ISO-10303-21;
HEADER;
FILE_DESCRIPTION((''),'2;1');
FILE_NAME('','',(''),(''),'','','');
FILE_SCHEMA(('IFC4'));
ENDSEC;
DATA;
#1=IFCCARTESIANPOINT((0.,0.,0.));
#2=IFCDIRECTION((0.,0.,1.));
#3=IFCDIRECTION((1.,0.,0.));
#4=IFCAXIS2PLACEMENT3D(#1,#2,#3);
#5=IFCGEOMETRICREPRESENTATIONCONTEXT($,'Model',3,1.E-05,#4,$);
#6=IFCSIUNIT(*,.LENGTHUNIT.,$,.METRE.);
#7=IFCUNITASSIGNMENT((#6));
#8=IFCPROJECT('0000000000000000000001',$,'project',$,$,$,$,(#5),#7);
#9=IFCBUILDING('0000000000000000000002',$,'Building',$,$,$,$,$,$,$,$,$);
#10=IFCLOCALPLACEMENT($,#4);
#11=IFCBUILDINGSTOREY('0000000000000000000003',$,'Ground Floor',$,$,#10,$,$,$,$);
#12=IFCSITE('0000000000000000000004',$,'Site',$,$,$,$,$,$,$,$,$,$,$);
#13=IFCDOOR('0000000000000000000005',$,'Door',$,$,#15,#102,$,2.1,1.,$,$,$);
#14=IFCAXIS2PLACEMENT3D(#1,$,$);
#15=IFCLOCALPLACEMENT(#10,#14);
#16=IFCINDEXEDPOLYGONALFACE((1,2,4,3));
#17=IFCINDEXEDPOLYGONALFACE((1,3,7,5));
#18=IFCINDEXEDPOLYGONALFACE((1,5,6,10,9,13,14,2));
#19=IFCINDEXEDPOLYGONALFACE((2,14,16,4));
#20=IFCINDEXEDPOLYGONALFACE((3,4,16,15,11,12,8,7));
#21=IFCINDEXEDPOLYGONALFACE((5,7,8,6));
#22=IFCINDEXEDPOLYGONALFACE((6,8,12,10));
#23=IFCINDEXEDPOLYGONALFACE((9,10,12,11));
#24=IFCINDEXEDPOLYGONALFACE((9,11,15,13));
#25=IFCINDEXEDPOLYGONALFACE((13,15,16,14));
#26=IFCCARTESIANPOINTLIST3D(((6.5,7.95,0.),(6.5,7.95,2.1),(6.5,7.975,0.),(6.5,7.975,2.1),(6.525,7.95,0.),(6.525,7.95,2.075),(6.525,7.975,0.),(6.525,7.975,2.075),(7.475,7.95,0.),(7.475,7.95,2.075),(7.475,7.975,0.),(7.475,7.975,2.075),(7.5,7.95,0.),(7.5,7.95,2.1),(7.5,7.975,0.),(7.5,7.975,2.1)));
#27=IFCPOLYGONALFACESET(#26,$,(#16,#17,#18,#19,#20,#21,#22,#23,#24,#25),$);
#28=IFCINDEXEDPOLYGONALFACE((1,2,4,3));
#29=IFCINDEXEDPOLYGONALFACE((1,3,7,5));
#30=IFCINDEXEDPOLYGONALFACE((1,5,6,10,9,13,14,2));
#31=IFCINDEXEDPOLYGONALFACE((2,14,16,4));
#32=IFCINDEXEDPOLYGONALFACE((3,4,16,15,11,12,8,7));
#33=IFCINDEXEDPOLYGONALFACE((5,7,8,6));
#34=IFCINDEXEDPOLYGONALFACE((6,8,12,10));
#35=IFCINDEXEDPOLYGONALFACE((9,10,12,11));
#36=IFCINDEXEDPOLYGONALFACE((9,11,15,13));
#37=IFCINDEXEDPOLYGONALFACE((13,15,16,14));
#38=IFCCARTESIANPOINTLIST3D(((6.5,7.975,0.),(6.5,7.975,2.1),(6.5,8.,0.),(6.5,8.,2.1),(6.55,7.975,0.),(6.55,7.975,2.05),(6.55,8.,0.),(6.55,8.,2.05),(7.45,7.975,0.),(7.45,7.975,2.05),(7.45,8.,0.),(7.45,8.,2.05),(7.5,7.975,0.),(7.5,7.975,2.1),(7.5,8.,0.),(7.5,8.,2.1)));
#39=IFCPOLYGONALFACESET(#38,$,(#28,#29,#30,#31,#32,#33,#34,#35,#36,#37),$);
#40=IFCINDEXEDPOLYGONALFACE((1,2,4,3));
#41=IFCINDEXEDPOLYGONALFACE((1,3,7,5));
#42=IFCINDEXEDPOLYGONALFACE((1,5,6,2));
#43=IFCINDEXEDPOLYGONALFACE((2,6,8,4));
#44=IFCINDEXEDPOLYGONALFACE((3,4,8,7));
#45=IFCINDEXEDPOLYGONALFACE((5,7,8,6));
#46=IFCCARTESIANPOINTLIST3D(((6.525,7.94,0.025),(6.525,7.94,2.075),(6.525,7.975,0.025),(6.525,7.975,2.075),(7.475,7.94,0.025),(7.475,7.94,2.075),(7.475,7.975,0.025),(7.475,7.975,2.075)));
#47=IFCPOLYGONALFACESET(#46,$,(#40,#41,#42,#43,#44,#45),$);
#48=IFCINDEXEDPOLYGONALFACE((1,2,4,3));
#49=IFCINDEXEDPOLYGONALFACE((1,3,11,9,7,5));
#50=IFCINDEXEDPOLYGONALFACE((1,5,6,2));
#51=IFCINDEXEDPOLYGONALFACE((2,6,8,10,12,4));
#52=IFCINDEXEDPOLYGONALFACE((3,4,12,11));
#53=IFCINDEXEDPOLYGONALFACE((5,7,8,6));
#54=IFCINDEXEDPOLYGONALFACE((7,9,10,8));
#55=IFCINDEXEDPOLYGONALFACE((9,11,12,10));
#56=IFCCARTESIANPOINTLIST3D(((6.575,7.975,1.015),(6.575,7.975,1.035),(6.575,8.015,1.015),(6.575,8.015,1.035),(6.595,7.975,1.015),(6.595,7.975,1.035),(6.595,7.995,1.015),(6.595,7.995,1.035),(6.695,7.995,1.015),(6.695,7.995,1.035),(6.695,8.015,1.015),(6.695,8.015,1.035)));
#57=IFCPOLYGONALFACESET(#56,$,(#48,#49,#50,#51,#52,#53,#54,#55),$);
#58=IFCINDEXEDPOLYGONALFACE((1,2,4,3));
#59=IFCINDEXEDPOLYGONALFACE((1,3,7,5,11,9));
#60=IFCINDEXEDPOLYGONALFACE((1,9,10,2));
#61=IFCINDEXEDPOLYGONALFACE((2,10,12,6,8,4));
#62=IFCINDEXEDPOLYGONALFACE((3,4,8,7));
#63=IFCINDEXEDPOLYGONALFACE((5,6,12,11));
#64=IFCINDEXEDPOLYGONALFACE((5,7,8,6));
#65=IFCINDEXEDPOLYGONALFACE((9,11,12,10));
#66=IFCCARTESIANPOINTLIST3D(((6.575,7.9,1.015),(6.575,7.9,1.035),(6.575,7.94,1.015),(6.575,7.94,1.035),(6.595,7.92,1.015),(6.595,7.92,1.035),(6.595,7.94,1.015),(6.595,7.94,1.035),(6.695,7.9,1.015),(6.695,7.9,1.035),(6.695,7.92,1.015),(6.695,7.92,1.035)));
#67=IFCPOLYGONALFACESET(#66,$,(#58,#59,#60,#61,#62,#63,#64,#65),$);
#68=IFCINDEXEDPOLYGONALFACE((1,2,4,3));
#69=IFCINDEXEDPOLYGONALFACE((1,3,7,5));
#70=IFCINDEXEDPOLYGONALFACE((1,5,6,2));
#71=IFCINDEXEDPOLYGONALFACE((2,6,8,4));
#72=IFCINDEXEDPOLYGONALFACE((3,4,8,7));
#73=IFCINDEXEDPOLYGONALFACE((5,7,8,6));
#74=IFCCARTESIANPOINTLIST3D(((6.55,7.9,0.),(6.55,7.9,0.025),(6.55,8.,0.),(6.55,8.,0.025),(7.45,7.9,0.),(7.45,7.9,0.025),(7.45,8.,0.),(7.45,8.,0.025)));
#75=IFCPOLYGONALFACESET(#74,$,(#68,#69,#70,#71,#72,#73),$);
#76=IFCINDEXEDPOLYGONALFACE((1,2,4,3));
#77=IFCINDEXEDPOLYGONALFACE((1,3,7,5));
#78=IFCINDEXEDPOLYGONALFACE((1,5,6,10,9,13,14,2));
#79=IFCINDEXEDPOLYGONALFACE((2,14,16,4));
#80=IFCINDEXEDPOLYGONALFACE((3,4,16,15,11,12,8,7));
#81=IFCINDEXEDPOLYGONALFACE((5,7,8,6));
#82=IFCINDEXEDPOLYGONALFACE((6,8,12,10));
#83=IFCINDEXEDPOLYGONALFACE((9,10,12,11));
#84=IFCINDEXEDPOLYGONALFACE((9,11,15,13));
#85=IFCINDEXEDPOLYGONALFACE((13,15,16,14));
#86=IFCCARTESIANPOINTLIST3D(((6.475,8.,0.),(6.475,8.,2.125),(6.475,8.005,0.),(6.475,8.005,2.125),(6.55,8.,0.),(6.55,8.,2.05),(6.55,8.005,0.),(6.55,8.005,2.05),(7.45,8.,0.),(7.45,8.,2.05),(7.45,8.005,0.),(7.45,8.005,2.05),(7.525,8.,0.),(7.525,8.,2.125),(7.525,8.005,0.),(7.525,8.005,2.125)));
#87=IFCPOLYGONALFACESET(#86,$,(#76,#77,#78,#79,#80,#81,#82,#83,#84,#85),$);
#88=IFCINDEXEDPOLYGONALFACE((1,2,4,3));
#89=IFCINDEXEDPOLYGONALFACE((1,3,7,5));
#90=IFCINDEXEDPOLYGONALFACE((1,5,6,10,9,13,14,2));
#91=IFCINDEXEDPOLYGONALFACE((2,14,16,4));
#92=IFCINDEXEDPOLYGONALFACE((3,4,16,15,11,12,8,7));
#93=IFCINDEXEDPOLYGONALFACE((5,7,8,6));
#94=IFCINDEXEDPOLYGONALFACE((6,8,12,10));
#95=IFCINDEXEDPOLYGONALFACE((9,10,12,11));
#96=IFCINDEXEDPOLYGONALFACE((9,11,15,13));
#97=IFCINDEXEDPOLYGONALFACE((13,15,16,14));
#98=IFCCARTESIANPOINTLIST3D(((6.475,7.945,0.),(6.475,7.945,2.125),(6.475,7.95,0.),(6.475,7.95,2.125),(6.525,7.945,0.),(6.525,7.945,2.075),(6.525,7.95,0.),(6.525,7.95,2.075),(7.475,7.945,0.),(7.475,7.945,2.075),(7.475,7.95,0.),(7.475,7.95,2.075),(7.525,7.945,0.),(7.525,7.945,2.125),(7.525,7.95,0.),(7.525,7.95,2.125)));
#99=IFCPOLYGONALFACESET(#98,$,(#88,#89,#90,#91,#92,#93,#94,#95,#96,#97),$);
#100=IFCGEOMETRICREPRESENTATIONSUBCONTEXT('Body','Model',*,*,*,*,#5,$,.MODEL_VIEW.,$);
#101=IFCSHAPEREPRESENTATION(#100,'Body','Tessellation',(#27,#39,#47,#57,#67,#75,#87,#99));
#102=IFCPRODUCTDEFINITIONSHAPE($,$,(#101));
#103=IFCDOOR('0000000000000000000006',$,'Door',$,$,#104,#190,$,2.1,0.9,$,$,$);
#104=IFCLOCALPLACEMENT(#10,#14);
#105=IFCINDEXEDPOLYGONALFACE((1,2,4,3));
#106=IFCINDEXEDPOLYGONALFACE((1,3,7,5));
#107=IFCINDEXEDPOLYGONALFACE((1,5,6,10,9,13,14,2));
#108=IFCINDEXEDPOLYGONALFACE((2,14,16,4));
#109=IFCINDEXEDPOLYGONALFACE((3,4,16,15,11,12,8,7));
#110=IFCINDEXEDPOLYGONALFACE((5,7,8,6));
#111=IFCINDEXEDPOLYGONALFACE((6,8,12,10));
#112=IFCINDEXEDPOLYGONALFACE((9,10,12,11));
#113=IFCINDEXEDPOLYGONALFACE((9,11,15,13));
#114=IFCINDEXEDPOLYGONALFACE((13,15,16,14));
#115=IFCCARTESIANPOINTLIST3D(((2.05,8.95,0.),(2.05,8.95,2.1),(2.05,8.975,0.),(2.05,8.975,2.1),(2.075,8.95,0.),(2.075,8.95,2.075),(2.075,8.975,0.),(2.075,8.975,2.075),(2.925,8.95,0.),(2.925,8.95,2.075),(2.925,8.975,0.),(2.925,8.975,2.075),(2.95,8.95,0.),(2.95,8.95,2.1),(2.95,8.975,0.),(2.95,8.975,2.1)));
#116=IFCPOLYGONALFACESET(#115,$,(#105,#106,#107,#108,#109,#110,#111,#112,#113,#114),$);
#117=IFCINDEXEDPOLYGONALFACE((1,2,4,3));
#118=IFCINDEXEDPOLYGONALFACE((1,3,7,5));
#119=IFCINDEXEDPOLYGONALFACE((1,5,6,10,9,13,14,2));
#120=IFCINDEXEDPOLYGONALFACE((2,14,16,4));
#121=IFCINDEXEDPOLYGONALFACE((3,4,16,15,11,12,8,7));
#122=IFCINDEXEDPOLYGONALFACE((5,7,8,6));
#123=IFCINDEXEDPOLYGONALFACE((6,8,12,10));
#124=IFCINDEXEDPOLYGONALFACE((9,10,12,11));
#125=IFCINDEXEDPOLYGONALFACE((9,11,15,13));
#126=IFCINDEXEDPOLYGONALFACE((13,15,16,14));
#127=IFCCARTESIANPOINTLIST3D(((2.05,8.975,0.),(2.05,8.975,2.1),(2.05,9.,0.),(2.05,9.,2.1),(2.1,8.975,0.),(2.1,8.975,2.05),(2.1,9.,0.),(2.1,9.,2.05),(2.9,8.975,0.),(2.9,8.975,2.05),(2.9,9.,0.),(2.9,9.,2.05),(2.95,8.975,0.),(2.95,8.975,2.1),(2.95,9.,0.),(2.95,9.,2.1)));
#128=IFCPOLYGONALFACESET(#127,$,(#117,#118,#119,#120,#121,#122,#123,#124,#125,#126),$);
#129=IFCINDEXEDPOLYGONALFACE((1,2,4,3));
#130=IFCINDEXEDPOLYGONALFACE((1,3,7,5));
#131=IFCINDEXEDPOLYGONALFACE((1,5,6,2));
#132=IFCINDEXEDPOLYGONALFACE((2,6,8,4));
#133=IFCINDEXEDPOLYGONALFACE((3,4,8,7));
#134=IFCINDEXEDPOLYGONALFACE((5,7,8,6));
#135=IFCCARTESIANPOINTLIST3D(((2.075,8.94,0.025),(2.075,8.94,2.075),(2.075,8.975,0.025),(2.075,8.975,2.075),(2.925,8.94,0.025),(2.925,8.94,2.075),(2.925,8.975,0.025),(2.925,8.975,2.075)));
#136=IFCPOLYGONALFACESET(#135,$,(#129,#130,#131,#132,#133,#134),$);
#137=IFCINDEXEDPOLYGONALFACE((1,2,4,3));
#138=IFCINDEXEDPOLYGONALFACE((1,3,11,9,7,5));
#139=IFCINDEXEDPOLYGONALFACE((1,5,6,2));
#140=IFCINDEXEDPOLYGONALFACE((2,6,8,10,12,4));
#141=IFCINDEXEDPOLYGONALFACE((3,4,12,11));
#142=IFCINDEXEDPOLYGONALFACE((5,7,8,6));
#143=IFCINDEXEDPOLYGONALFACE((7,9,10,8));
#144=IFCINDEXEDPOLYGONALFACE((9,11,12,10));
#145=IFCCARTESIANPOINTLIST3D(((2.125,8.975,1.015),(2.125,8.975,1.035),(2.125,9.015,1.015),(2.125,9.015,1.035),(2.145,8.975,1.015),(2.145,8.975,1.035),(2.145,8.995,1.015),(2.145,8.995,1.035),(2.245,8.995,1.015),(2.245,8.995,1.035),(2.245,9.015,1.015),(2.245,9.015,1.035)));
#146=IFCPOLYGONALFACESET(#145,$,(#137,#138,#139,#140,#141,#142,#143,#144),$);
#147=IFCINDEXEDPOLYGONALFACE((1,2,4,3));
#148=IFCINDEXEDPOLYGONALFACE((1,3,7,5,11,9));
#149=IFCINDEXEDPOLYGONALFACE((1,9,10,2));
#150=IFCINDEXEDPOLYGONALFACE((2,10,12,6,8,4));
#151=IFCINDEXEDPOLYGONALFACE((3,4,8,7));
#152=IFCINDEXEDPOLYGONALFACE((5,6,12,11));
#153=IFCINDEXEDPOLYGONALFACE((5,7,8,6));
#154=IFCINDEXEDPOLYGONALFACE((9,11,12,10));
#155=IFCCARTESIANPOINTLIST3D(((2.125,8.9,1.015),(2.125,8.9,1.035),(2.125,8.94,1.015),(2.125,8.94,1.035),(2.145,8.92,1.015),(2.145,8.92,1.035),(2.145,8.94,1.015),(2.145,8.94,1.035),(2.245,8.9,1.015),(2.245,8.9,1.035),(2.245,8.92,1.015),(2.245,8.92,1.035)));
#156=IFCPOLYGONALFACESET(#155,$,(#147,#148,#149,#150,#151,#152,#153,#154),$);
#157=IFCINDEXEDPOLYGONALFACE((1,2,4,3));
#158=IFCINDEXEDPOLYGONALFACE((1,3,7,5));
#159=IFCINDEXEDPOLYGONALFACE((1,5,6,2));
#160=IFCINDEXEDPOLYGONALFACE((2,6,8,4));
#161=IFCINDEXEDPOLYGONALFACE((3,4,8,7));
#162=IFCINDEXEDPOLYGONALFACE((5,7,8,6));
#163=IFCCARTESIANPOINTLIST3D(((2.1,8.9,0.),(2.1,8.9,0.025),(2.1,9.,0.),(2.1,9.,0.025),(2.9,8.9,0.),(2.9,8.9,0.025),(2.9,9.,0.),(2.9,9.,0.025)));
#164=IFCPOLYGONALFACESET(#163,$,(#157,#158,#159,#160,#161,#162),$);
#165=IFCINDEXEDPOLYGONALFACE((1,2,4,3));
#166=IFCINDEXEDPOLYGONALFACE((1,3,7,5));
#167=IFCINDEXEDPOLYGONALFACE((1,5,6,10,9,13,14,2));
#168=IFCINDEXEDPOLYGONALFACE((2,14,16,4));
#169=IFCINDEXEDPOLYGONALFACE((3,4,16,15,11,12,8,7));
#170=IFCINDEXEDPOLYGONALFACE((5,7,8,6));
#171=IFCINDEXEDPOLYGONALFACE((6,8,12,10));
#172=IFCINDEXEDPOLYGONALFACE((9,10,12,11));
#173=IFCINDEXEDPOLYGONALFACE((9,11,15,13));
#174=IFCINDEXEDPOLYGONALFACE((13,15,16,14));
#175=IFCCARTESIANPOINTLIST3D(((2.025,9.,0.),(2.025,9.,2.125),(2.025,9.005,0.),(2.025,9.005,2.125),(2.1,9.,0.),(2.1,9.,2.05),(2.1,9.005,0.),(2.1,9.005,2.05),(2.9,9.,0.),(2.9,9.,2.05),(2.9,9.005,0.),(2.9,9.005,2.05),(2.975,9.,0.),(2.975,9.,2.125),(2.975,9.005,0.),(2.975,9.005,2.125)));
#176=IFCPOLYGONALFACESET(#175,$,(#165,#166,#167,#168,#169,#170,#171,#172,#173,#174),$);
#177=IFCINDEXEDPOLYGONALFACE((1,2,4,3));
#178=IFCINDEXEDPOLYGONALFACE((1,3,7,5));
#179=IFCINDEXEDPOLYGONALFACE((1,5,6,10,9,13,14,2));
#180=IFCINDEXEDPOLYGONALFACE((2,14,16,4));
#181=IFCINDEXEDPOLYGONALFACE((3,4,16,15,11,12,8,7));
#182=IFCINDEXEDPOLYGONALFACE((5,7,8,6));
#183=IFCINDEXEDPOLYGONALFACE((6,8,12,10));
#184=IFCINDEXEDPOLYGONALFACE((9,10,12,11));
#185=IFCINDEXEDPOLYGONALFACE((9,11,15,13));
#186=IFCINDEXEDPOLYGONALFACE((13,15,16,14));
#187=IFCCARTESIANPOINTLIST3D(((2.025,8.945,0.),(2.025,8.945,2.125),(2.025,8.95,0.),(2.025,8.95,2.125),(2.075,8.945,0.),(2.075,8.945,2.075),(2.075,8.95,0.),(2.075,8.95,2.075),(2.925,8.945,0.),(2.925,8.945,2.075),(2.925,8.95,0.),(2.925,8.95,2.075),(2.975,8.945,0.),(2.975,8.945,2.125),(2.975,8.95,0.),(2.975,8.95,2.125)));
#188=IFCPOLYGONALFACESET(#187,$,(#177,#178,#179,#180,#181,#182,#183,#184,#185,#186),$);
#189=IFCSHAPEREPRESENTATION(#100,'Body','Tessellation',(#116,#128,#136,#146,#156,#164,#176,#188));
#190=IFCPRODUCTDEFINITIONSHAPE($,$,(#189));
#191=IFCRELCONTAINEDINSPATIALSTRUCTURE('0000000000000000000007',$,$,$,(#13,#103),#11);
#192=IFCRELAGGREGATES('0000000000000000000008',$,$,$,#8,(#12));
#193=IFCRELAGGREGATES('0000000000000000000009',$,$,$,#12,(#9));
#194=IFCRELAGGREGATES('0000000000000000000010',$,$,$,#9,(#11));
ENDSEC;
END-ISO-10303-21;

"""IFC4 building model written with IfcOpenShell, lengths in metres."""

from ifc_helpers import new_model, si_unit, frame, origin_with_axes, place, context, subcontext, project, spatial, line, indexed_curve, outline, extrude, element, save


model = new_model("IFC4")

# Units and contexts
model_context = context("Model", 3, precision=1e-05, world=origin_with_axes())
body_context = subcontext(model_context, "Body", "Model", "MODEL_VIEW")
ifc_project = project(units=[si_unit("LENGTHUNIT", "METRE")], contexts=[model_context])

# Site, building, storey
site = spatial("IfcSite", under=ifc_project, Name="Site")
building = spatial("IfcBuilding", under=site, Name="Building")
storey_placement = place(None, origin_with_axes())
storey = spatial("IfcBuildingStorey", under=building, at=storey_placement, Name="Ground Floor")

# Doors
door_1_placement = place(storey_placement, frame((7.5, 8.0, 0.0), z_axis=(0.0, 0.0, 1.0), x_axis=(-1.0, 0.0, 0.0)))
element("IfcDoor", 1, at=door_1_placement, inside=storey, Name="Door", OverallHeight=2.1, OverallWidth=1.0, context=body_context, shape_type="SweptSolid", body=[
    extrude(outline(indexed_curve([(0.0, 0.0), (0.0, 2.1), (1.0, 2.1), (1.0, 0.0), (0.975, 0.0), (0.975, 2.075), (0.025, 2.075), (0.025, 0.0)], segments=[line(1, 2, 3, 4, 5, 6, 7, 8, 1)])), frame((0.0, 0.025, 0.0), z_axis=(0.0, -1.0, 0.0), x_axis=(1.0, 0.0, 0.0)), (0.0, 0.0, -1.0), 0.025),
    extrude(outline(indexed_curve([(0.0, 0.0), (0.0, 2.1), (1.0, 2.1), (1.0, 0.0), (0.95, 0.0), (0.95, 2.05), (0.05, 2.05), (0.05, 0.0)], segments=[line(1, 2, 3, 4, 5, 6, 7, 8, 1)])), frame((0.0, 0.0, 0.0), z_axis=(0.0, -1.0, 0.0), x_axis=(1.0, 0.0, 0.0)), (0.0, 0.0, -1.0), 0.025),
    extrude(outline(indexed_curve([(0.0, 0.0), (0.95, 0.0), (0.95, 0.035), (0.0, 0.035)], segments=[line(1, 2, 3, 4, 1)])), frame((0.025, 0.025, 0.025), z_axis=(0.0, 0.0, 1.0), x_axis=(1.0, 0.0, 0.0)), (0.0, 0.0, 1.0), 2.05),
    extrude(outline(indexed_curve([(0.0, 0.0), (0.0, -0.04), (-0.12, -0.04), (-0.12, -0.02), (-0.02, -0.02), (-0.02, 0.0)], segments=[line(1, 2, 3, 4, 5, 6, 1)])), frame((0.925, 0.025, 1.015), z_axis=(0.0, 0.0, 1.0), x_axis=(1.0, 0.0, 0.0)), (0.0, 0.0, 1.0), 0.02),
    extrude(outline(indexed_curve([(0.0, 0.0), (0.0, 0.04), (-0.12, 0.04), (-0.12, 0.02), (-0.02, 0.02), (-0.02, 0.0)], segments=[line(1, 2, 3, 4, 5, 6, 1)])), frame((0.925, 0.06, 1.015), z_axis=(0.0, 0.0, 1.0), x_axis=(1.0, 0.0, 0.0)), (0.0, 0.0, 1.0), 0.02),
    extrude(outline(indexed_curve([(0.0, 0.0), (0.9, 0.0), (0.9, 0.1), (0.0, 0.1)], segments=[line(1, 2, 3, 4, 1)])), frame((0.05, 0.0, 0.0), z_axis=(0.0, 0.0, 1.0), x_axis=(1.0, 0.0, 0.0)), (0.0, 0.0, 1.0), 0.025),
    extrude(outline(indexed_curve([(0.0, 0.0), (0.0, 2.125), (1.05, 2.125), (1.05, 0.0), (0.975, 0.0), (0.975, 2.05), (0.075, 2.05), (0.075, 0.0)], segments=[line(1, 2, 3, 4, 5, 6, 7, 8, 1)])), frame((-0.025, -0.005, 0.0), z_axis=(0.0, -1.0, 0.0), x_axis=(1.0, 0.0, 0.0)), (0.0, 0.0, -1.0), 0.005),
    extrude(outline(indexed_curve([(0.0, 0.0), (0.0, 2.125), (1.05, 2.125), (1.05, 0.0), (1.0, 0.0), (1.0, 2.075), (0.05, 2.075), (0.05, 0.0)], segments=[line(1, 2, 3, 4, 5, 6, 7, 8, 1)])), frame((-0.025, 0.05, 0.0), z_axis=(0.0, -1.0, 0.0), x_axis=(1.0, 0.0, 0.0)), (0.0, 0.0, -1.0), 0.005),
])
door_2_placement = place(storey_placement, frame((2.95, 9.0, 0.0), z_axis=(0.0, 0.0, 1.0), x_axis=(-1.0, 0.0, 0.0)))
element("IfcDoor", 2, at=door_2_placement, inside=storey, Name="Door", OverallHeight=2.1, OverallWidth=0.9, context=body_context, shape_type="SweptSolid", body=[
    extrude(outline(indexed_curve([(0.0, 0.0), (0.0, 2.1), (0.9, 2.1), (0.9, 0.0), (0.875, 0.0), (0.875, 2.075), (0.025, 2.075), (0.025, 0.0)], segments=[line(1, 2, 3, 4, 5, 6, 7, 8, 1)])), frame((0.0, 0.025, 0.0), z_axis=(0.0, -1.0, 0.0), x_axis=(1.0, 0.0, 0.0)), (0.0, 0.0, -1.0), 0.025),
    extrude(outline(indexed_curve([(0.0, 0.0), (0.0, 2.1), (0.9, 2.1), (0.9, 0.0), (0.85, 0.0), (0.85, 2.05), (0.05, 2.05), (0.05, 0.0)], segments=[line(1, 2, 3, 4, 5, 6, 7, 8, 1)])), frame((0.0, 0.0, 0.0), z_axis=(0.0, -1.0, 0.0), x_axis=(1.0, 0.0, 0.0)), (0.0, 0.0, -1.0), 0.025),
    extrude(outline(indexed_curve([(0.0, 0.0), (0.85, 0.0), (0.85, 0.035), (0.0, 0.035)], segments=[line(1, 2, 3, 4, 1)])), frame((0.025, 0.025, 0.025), z_axis=(0.0, 0.0, 1.0), x_axis=(1.0, 0.0, 0.0)), (0.0, 0.0, 1.0), 2.05),
    extrude(outline(indexed_curve([(0.0, 0.0), (0.0, -0.04), (-0.12, -0.04), (-0.12, -0.02), (-0.02, -0.02), (-0.02, 0.0)], segments=[line(1, 2, 3, 4, 5, 6, 1)])), frame((0.825, 0.025, 1.015), z_axis=(0.0, 0.0, 1.0), x_axis=(1.0, 0.0, 0.0)), (0.0, 0.0, 1.0), 0.02),
    extrude(outline(indexed_curve([(0.0, 0.0), (0.0, 0.04), (-0.12, 0.04), (-0.12, 0.02), (-0.02, 0.02), (-0.02, 0.0)], segments=[line(1, 2, 3, 4, 5, 6, 1)])), frame((0.825, 0.06, 1.015), z_axis=(0.0, 0.0, 1.0), x_axis=(1.0, 0.0, 0.0)), (0.0, 0.0, 1.0), 0.02),
    extrude(outline(indexed_curve([(0.0, 0.0), (0.8, 0.0), (0.8, 0.1), (0.0, 0.1)], segments=[line(1, 2, 3, 4, 1)])), frame((0.05, 0.0, 0.0), z_axis=(0.0, 0.0, 1.0), x_axis=(1.0, 0.0, 0.0)), (0.0, 0.0, 1.0), 0.025),
    extrude(outline(indexed_curve([(0.0, 0.0), (0.0, 2.125), (0.95, 2.125), (0.95, 0.0), (0.875, 0.0), (0.875, 2.05), (0.075, 2.05), (0.075, 0.0)], segments=[line(1, 2, 3, 4, 5, 6, 7, 8, 1)])), frame((-0.025, -0.005, 0.0), z_axis=(0.0, -1.0, 0.0), x_axis=(1.0, 0.0, 0.0)), (0.0, 0.0, -1.0), 0.005),
    extrude(outline(indexed_curve([(0.0, 0.0), (0.0, 2.125), (0.95, 2.125), (0.95, 0.0), (0.9, 0.0), (0.9, 2.075), (0.05, 2.075), (0.05, 0.0)], segments=[line(1, 2, 3, 4, 5, 6, 7, 8, 1)])), frame((-0.025, 0.05, 0.0), z_axis=(0.0, -1.0, 0.0), x_axis=(1.0, 0.0, 0.0)), (0.0, 0.0, -1.0), 0.005),
])

save(model, "model.ifc")
